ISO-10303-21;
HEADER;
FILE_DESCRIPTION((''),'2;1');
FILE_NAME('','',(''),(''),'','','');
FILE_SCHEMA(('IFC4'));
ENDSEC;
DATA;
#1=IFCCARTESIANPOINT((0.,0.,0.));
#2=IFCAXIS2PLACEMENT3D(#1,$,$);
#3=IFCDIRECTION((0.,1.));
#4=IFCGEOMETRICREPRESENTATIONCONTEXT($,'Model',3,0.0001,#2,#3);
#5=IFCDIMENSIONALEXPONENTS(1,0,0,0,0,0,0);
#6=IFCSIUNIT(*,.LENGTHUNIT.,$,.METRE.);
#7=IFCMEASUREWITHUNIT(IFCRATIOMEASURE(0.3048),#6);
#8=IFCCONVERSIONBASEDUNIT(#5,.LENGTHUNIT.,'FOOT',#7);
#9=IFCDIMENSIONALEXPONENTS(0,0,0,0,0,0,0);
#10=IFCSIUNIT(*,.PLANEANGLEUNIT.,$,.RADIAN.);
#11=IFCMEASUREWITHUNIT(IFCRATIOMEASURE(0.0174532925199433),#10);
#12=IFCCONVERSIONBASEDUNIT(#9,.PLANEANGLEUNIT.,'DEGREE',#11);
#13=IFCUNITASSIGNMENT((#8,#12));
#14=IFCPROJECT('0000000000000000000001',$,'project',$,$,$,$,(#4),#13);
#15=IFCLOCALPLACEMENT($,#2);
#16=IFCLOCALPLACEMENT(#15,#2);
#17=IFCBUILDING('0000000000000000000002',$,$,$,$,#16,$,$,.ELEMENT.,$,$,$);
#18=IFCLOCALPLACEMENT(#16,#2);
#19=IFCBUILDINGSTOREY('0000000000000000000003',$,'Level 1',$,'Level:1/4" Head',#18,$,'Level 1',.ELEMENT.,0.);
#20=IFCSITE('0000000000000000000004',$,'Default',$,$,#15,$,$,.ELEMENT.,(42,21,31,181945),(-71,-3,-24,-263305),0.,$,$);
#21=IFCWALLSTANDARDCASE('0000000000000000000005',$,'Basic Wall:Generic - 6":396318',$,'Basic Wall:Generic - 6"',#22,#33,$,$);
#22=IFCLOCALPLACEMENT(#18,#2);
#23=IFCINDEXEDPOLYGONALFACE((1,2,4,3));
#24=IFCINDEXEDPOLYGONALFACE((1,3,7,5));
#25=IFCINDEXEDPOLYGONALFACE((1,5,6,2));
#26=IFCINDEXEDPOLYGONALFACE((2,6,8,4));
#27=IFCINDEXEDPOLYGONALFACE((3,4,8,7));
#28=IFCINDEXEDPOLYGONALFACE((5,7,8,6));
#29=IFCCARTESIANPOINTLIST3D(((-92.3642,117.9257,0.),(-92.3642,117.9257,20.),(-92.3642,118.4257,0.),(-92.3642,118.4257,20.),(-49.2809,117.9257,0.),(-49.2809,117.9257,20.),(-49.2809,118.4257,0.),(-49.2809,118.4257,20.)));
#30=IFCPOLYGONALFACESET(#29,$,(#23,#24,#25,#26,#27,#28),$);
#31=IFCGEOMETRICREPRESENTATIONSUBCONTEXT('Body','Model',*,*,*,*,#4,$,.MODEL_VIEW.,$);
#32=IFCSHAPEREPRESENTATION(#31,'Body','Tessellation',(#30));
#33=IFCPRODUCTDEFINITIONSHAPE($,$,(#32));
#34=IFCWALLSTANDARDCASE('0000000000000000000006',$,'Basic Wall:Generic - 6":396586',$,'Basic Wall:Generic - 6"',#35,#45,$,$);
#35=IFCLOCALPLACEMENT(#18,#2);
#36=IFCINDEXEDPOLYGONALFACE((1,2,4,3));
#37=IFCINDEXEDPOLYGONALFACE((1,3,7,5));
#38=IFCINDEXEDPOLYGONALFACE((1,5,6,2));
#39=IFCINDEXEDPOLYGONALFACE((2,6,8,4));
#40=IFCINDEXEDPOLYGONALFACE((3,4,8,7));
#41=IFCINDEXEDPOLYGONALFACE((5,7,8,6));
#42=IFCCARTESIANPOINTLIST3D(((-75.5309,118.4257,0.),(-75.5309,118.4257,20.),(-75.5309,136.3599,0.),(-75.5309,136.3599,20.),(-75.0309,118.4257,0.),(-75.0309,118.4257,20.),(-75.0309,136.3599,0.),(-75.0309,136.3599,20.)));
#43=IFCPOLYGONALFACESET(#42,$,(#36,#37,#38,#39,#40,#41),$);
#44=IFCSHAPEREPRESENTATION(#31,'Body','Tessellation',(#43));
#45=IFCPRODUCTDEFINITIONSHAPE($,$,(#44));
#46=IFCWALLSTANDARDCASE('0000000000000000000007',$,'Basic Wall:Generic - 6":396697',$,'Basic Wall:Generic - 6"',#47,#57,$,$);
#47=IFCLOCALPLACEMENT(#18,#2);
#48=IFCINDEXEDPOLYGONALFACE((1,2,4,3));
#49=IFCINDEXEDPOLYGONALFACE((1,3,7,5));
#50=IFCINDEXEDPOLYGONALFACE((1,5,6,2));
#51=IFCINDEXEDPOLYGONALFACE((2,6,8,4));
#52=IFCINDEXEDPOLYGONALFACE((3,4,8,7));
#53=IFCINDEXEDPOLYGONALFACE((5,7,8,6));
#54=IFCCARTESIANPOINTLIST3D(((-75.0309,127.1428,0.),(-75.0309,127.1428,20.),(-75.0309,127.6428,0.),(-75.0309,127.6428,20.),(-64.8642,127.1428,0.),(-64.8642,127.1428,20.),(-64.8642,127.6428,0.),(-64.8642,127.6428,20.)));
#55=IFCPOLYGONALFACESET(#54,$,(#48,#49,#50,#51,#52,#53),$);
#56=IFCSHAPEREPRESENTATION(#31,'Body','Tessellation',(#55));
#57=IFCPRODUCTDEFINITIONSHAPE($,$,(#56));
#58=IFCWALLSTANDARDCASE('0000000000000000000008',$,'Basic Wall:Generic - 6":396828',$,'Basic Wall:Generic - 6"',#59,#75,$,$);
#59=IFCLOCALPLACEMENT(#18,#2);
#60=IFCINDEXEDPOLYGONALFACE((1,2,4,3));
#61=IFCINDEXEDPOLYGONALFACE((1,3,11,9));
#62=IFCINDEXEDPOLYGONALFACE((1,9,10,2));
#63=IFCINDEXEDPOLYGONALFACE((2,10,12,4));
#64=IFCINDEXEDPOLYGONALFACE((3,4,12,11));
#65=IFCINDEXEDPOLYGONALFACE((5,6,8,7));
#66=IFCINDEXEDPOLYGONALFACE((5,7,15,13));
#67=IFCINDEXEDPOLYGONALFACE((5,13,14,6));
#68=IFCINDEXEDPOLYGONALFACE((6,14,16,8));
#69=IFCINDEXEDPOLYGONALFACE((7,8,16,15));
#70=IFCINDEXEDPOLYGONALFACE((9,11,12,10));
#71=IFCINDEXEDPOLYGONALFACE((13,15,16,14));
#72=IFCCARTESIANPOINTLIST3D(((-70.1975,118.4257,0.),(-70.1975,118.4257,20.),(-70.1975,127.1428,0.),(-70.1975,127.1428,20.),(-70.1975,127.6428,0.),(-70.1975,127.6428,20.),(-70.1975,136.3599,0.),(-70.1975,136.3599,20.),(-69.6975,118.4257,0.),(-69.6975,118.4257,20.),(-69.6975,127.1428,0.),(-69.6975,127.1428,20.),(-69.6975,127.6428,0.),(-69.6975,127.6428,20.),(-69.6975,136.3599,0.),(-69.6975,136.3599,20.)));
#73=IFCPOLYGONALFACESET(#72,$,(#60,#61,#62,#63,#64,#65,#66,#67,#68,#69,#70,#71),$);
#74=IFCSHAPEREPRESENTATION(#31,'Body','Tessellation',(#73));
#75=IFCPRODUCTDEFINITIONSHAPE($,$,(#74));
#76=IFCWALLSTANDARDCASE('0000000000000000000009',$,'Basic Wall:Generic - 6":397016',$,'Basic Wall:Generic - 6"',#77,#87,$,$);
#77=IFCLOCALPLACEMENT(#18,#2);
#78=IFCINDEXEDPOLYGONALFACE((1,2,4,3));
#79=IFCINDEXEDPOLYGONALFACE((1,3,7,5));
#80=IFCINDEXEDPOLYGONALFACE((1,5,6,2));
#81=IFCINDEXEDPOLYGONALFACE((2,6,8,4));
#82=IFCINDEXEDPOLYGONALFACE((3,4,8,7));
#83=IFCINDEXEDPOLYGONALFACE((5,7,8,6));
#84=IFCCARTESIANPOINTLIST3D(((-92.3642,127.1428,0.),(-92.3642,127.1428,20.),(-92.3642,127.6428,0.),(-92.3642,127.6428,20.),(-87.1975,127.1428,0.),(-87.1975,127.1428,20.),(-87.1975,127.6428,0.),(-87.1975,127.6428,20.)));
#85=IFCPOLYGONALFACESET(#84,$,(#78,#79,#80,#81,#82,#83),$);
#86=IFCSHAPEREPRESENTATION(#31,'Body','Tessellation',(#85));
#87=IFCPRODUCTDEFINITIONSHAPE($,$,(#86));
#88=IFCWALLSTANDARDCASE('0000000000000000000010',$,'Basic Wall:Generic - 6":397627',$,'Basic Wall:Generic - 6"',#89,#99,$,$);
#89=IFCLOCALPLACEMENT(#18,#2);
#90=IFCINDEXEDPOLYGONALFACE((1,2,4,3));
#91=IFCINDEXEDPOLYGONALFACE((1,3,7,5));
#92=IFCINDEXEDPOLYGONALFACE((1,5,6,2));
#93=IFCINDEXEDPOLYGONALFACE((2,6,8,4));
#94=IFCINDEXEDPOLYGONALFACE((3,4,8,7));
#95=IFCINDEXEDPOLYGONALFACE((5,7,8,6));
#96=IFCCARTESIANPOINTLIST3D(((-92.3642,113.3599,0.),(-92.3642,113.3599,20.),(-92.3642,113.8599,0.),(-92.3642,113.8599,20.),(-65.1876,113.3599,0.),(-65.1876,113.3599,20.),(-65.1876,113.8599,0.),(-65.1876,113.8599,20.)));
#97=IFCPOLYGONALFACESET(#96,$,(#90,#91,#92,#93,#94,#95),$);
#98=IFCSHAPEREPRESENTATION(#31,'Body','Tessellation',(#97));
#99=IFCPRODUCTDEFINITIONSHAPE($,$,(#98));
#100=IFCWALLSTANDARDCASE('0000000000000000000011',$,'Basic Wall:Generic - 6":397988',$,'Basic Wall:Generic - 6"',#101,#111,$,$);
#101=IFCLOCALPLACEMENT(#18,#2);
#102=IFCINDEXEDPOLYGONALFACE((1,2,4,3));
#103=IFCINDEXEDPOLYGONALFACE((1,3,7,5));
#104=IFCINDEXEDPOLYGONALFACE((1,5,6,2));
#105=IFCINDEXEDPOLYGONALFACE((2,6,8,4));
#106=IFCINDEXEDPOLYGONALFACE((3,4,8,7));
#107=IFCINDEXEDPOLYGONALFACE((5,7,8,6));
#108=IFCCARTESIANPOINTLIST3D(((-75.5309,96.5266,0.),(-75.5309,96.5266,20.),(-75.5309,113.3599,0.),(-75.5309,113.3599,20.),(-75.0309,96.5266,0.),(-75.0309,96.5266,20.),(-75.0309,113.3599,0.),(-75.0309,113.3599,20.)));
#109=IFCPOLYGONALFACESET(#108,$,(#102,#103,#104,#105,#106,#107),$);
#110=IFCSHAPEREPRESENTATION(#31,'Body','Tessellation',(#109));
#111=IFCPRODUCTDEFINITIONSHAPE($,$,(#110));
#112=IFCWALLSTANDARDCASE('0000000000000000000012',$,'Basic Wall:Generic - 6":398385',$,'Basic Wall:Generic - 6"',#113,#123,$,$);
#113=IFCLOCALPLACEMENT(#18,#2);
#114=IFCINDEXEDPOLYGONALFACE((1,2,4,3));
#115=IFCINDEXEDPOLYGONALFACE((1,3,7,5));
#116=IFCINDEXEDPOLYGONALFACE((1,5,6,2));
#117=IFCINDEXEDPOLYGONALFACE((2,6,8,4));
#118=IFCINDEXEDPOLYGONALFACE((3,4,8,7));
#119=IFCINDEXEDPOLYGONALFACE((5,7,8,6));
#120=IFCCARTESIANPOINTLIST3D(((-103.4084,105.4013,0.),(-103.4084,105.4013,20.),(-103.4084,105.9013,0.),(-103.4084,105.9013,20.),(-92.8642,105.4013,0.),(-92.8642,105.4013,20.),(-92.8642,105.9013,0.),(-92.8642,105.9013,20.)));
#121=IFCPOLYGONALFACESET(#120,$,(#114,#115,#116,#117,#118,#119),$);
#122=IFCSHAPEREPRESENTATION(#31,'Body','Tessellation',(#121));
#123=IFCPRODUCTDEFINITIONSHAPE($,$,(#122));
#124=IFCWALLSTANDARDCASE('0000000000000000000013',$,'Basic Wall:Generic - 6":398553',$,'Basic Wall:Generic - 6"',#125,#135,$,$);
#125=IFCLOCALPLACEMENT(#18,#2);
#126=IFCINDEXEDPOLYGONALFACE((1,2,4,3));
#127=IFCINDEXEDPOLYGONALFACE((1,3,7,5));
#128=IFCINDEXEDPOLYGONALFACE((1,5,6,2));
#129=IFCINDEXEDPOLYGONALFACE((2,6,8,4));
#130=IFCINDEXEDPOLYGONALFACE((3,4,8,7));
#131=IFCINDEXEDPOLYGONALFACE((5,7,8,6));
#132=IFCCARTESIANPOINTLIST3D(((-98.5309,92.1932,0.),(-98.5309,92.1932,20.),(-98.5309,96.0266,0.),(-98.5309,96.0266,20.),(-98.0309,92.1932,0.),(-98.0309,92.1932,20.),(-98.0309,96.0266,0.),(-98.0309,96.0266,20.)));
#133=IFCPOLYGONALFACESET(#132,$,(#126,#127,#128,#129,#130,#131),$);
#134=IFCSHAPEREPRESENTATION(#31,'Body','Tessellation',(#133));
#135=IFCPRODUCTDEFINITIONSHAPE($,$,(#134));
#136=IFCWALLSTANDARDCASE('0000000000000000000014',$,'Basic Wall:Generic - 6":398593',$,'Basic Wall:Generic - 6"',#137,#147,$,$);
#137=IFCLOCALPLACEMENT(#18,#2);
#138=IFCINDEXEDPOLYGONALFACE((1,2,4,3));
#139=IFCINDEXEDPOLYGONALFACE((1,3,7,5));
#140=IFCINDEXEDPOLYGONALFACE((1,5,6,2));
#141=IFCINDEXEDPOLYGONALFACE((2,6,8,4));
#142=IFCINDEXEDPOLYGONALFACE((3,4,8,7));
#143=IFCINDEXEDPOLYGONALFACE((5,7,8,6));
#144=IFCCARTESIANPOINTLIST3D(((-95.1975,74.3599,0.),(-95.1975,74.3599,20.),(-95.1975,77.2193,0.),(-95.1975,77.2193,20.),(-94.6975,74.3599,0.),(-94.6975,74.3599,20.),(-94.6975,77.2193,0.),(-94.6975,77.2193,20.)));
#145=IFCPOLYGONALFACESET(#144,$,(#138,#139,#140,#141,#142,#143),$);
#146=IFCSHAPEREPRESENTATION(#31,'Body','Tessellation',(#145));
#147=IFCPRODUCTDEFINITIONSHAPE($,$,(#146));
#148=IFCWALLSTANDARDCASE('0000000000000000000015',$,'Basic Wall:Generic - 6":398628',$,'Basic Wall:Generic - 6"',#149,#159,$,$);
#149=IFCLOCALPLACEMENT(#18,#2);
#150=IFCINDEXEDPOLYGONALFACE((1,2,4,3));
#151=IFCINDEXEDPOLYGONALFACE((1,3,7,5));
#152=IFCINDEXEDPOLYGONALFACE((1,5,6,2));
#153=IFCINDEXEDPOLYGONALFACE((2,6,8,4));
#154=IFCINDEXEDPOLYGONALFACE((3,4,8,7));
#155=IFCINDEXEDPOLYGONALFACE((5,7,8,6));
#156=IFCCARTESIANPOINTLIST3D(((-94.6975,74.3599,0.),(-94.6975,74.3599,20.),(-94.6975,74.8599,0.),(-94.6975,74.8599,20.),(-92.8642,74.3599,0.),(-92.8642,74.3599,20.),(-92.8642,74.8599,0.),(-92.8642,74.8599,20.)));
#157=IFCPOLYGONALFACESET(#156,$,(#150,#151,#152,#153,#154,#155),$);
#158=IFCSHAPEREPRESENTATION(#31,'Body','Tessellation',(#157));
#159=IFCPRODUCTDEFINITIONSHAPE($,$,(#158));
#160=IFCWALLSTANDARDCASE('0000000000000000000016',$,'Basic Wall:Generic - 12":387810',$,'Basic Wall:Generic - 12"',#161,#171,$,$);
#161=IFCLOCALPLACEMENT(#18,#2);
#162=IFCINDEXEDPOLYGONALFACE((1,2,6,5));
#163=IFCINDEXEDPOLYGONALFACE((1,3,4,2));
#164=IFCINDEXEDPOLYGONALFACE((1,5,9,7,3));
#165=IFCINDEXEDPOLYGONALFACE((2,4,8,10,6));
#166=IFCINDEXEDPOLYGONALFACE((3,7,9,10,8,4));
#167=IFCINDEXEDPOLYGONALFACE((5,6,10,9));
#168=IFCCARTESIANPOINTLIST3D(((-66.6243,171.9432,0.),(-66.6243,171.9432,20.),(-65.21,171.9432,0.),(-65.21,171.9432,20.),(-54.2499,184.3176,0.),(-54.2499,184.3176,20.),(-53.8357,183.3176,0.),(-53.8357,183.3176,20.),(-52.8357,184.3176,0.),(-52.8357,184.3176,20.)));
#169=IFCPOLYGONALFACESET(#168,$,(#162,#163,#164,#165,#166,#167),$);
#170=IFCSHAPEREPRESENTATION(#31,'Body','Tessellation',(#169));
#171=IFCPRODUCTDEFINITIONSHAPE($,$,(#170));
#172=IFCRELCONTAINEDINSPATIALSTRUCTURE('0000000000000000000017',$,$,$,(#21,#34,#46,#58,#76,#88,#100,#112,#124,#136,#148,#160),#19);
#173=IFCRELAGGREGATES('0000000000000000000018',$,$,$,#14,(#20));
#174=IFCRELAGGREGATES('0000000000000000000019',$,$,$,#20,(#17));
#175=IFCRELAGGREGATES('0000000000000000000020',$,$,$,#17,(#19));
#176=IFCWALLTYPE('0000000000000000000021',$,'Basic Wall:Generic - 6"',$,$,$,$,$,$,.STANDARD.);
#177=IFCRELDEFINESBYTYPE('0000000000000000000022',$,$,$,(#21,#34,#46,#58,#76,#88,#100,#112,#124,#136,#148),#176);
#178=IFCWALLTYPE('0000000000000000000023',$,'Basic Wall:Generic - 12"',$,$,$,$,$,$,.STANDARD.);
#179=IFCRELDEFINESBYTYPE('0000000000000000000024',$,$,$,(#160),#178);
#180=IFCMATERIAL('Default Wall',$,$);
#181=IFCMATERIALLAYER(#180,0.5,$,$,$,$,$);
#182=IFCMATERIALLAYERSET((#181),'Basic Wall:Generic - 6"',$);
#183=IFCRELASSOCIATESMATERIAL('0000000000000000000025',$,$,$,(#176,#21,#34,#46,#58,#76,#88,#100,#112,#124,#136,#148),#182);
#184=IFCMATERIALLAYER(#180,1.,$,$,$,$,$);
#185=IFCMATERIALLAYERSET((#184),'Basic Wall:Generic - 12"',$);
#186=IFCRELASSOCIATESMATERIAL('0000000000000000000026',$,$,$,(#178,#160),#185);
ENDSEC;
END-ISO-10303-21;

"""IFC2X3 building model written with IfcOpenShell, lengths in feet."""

from ifc_helpers import new_model, entity, si_unit, converted_unit, direction, frame, frame_2d, origin, origin_2d_with_axis, place, context, subcontext, project, spatial, polyline, rectangle, outline, extrude, material, layer, layer_set, layer_usage, type_object, element, save


model = new_model("IFC2X3")

# Units and contexts
model_context = context("Model", 3, precision=0.0001, world=origin(), true_north=direction((0.0, 1.0)))
body_context = subcontext(model_context, "Body", "Model", "MODEL_VIEW")
ifc_project = project(units=[converted_unit("LENGTHUNIT", "FOOT", entity("IfcRatioMeasure", 0.3048), si_unit("LENGTHUNIT", "METRE"), dimensions=[1, 0, 0, 0, 0, 0, 0]), converted_unit("PLANEANGLEUNIT", "DEGREE", entity("IfcRatioMeasure", 0.0174532925199433), si_unit("PLANEANGLEUNIT", "RADIAN"), dimensions=[0, 0, 0, 0, 0, 0, 0])], contexts=[model_context])

# Site, building, storey
site_placement = place(None, origin())
site = spatial("IfcSite", under=ifc_project, at=site_placement, Name="Default", CompositionType="ELEMENT", RefLatitude=(42, 21, 31, 181945), RefLongitude=(-71, -3, -24, -263305), RefElevation=0.0)
building_placement = place(site_placement, origin())
building = spatial("IfcBuilding", under=site, at=building_placement, CompositionType="ELEMENT")
storey_placement = place(building_placement, origin())
storey = spatial("IfcBuildingStorey", under=building, at=storey_placement, Name="Level 1", ObjectType="Level:1/4\" Head", LongName="Level 1", CompositionType="ELEMENT", Elevation=0.0)

# Walls
ifc_material = material(Name="Default Wall")
ifc_layer_1 = layer(ifc_material, 0.5)
ifc_layer_set_1 = layer_set([ifc_layer_1], Name="Basic Wall:Generic - 6\"")
wall_type_1 = type_object("IfcWallType", Name="Basic Wall:Generic - 6\"", PredefinedType="STANDARD", material=ifc_layer_set_1)
ifc_layer_usage_1 = layer_usage(ifc_layer_set_1, "AXIS2", "NEGATIVE", 0.25)
wall_1_placement = place(storey_placement, frame((-92.3642, 118.1757, 0.0)))
element("IfcWallStandardCase", 1, at=wall_1_placement, inside=storey, type_object=wall_type_1, material=ifc_layer_usage_1, Name="Basic Wall:Generic - 6\":396318", ObjectType="Basic Wall:Generic - 6\"", context=body_context, shape_type="SweptSolid", body=[
    extrude(rectangle(XDim=43.0833, YDim=0.5, at=frame_2d((21.5417, 0.0), x_axis=(-1.0, 0.0))), origin(), (0.0, 0.0, 1.0), 20.0),
])
ifc_layer_usage_2 = layer_usage(ifc_layer_set_1, "AXIS2", "NEGATIVE", 0.25)
wall_2_placement = place(storey_placement, frame((-75.2809, 118.4257, 0.0), z_axis=(0.0, 0.0, 1.0), x_axis=(0.0, 1.0, 0.0)))
element("IfcWallStandardCase", 2, at=wall_2_placement, inside=storey, type_object=wall_type_1, material=ifc_layer_usage_2, Name="Basic Wall:Generic - 6\":396586", ObjectType="Basic Wall:Generic - 6\"", context=body_context, shape_type="SweptSolid", body=[
    extrude(rectangle(XDim=17.9342, YDim=0.5, at=frame_2d((8.9671, 0.0), x_axis=(-1.0, 0.0))), origin(), (0.0, 0.0, 1.0), 20.0),
])
ifc_layer_usage_3 = layer_usage(ifc_layer_set_1, "AXIS2", "NEGATIVE", 0.25)
wall_3_placement = place(storey_placement, frame((-75.0309, 127.3928, 0.0)))
element("IfcWallStandardCase", 3, at=wall_3_placement, inside=storey, type_object=wall_type_1, material=ifc_layer_usage_3, Name="Basic Wall:Generic - 6\":396697", ObjectType="Basic Wall:Generic - 6\"", context=body_context, shape_type="SweptSolid", body=[
    extrude(rectangle(XDim=10.1667, YDim=0.5, at=frame_2d((5.0833, 0.0), x_axis=(-1.0, 0.0))), origin(), (0.0, 0.0, 1.0), 20.0),
])

# Wall, opening
ifc_layer_usage_4 = layer_usage(ifc_layer_set_1, "AXIS2", "NEGATIVE", 0.25)
wall_4_placement = place(storey_placement, frame((-69.9475, 118.4257, 0.0), z_axis=(0.0, 0.0, 1.0), x_axis=(0.0, 1.0, 0.0)))
wall_4 = element("IfcWallStandardCase", 4, at=wall_4_placement, inside=storey, type_object=wall_type_1, material=ifc_layer_usage_4, Name="Basic Wall:Generic - 6\":396828", ObjectType="Basic Wall:Generic - 6\"", context=body_context, shape_type="SweptSolid", body=[
    extrude(rectangle(XDim=17.9342, YDim=0.5, at=frame_2d((8.9671, 0.0), x_axis=(-1.0, 0.0))), origin(), (0.0, 0.0, 1.0), 20.0),
])
opening_placement = place(storey_placement, frame((-69.9475, 118.4257, 0.0), z_axis=(0.0, 0.0, 1.0), x_axis=(0.0, 1.0, 0.0)))
element("IfcOpeningElement", 5, at=opening_placement, cuts=wall_4, ObjectType="Opening", context=body_context, shape_type="SweptSolid", body=[
    extrude(rectangle(XDim=20.0, YDim=0.5, at=origin_2d_with_axis()), frame((8.7171, 0.0, 10.0), z_axis=(1.0, 0.0, 0.0), x_axis=(0.0, 0.0, -1.0)), (0.0, 0.0, 1.0), 0.5),
])

# Walls
ifc_layer_usage_5 = layer_usage(ifc_layer_set_1, "AXIS2", "NEGATIVE", 0.25)
wall_5_placement = place(storey_placement, frame((-87.1975, 127.3928, 0.0), z_axis=(0.0, 0.0, 1.0), x_axis=(-1.0, 0.0, 0.0)))
element("IfcWallStandardCase", 6, at=wall_5_placement, inside=storey, type_object=wall_type_1, material=ifc_layer_usage_5, Name="Basic Wall:Generic - 6\":397016", ObjectType="Basic Wall:Generic - 6\"", context=body_context, shape_type="SweptSolid", body=[
    extrude(rectangle(XDim=5.1667, YDim=0.5, at=frame_2d((2.5833, 0.0), x_axis=(-1.0, 0.0))), origin(), (0.0, 0.0, 1.0), 20.0),
])
ifc_layer_usage_6 = layer_usage(ifc_layer_set_1, "AXIS2", "NEGATIVE", 0.25)
wall_6_placement = place(storey_placement, frame((-92.3642, 113.6099, 0.0)))
element("IfcWallStandardCase", 7, at=wall_6_placement, inside=storey, type_object=wall_type_1, material=ifc_layer_usage_6, Name="Basic Wall:Generic - 6\":397627", ObjectType="Basic Wall:Generic - 6\"", context=body_context, shape_type="SweptSolid", body=[
    extrude(rectangle(XDim=27.1766, YDim=0.5, at=frame_2d((13.5883, 0.0), x_axis=(-1.0, 0.0))), origin(), (0.0, 0.0, 1.0), 20.0),
])
ifc_layer_usage_7 = layer_usage(ifc_layer_set_1, "AXIS2", "NEGATIVE", 0.25)
wall_7_placement = place(storey_placement, frame((-75.2809, 96.5266, 0.0), z_axis=(0.0, 0.0, 1.0), x_axis=(0.0, 1.0, 0.0)))
element("IfcWallStandardCase", 8, at=wall_7_placement, inside=storey, type_object=wall_type_1, material=ifc_layer_usage_7, Name="Basic Wall:Generic - 6\":397988", ObjectType="Basic Wall:Generic - 6\"", context=body_context, shape_type="SweptSolid", body=[
    extrude(rectangle(XDim=16.8333, YDim=0.5, at=frame_2d((8.4167, 0.0), x_axis=(-1.0, 0.0))), origin(), (0.0, 0.0, 1.0), 20.0),
])
ifc_layer_usage_8 = layer_usage(ifc_layer_set_1, "AXIS2", "NEGATIVE", 0.25)
wall_8_placement = place(storey_placement, frame((-103.4084, 105.6513, 0.0)))
element("IfcWallStandardCase", 9, at=wall_8_placement, inside=storey, type_object=wall_type_1, material=ifc_layer_usage_8, Name="Basic Wall:Generic - 6\":398385", ObjectType="Basic Wall:Generic - 6\"", context=body_context, shape_type="SweptSolid", body=[
    extrude(rectangle(XDim=10.5442, YDim=0.5, at=frame_2d((5.2721, 0.0), x_axis=(-1.0, 0.0))), origin(), (0.0, 0.0, 1.0), 20.0),
])
ifc_layer_usage_9 = layer_usage(ifc_layer_set_1, "AXIS2", "NEGATIVE", 0.25)
wall_9_placement = place(storey_placement, frame((-98.2809, 92.1932, 0.0), z_axis=(0.0, 0.0, 1.0), x_axis=(0.0, 1.0, 0.0)))
element("IfcWallStandardCase", 10, at=wall_9_placement, inside=storey, type_object=wall_type_1, material=ifc_layer_usage_9, Name="Basic Wall:Generic - 6\":398553", ObjectType="Basic Wall:Generic - 6\"", context=body_context, shape_type="SweptSolid", body=[
    extrude(rectangle(XDim=3.8333, YDim=0.5, at=frame_2d((1.9167, 0.0), x_axis=(-1.0, 0.0))), origin(), (0.0, 0.0, 1.0), 20.0),
])
ifc_layer_usage_10 = layer_usage(ifc_layer_set_1, "AXIS2", "NEGATIVE", 0.25)
wall_10_placement = place(storey_placement, frame((-94.9475, 77.2193, 0.0), z_axis=(0.0, 0.0, 1.0), x_axis=(0.0, -1.0, 0.0)))
element("IfcWallStandardCase", 11, at=wall_10_placement, inside=storey, type_object=wall_type_1, material=ifc_layer_usage_10, Name="Basic Wall:Generic - 6\":398593", ObjectType="Basic Wall:Generic - 6\"", context=body_context, shape_type="SweptSolid", body=[
    extrude(rectangle(XDim=2.8594, YDim=0.5, at=frame_2d((1.4297, 0.0), x_axis=(-1.0, 0.0))), origin(), (0.0, 0.0, 1.0), 20.0),
])
ifc_layer_usage_11 = layer_usage(ifc_layer_set_1, "AXIS2", "NEGATIVE", 0.25)
wall_11_placement = place(storey_placement, frame((-94.6975, 74.6099, 0.0)))
element("IfcWallStandardCase", 12, at=wall_11_placement, inside=storey, type_object=wall_type_1, material=ifc_layer_usage_11, Name="Basic Wall:Generic - 6\":398628", ObjectType="Basic Wall:Generic - 6\"", context=body_context, shape_type="SweptSolid", body=[
    extrude(rectangle(XDim=1.8333, YDim=0.5, at=frame_2d((0.9167, 0.0), x_axis=(-1.0, 0.0))), origin(), (0.0, 0.0, 1.0), 20.0),
])
ifc_layer_2 = layer(ifc_material, 1.0)
ifc_layer_set_2 = layer_set([ifc_layer_2], Name="Basic Wall:Generic - 12\"")
ifc_layer_usage_12 = layer_usage(ifc_layer_set_2, "AXIS2", "NEGATIVE", 0.5)
wall_type_2 = type_object("IfcWallType", Name="Basic Wall:Generic - 12\"", PredefinedType="STANDARD", material=ifc_layer_set_2)
wall_12_placement = place(storey_placement, frame((-66.2707, 171.5897, 0.0), z_axis=(0.0, 0.0, 1.0), x_axis=(0.707107, 0.707107, 0.0)))
element("IfcWallStandardCase", 13, at=wall_12_placement, inside=storey, type_object=wall_type_2, material=ifc_layer_usage_12, Name="Basic Wall:Generic - 12\":387810", ObjectType="Basic Wall:Generic - 12\"", context=body_context, shape_type="SweptSolid", body=[
    extrude(outline(polyline([(18.5, -0.5), (17.5, 0.5), (0.0, 0.5), (1.0, -0.5), (17.0858, -0.5), (18.5, -0.5)])), origin(), (0.0, 0.0, 1.0), 20.0),
])

save(model, "model.ifc")
